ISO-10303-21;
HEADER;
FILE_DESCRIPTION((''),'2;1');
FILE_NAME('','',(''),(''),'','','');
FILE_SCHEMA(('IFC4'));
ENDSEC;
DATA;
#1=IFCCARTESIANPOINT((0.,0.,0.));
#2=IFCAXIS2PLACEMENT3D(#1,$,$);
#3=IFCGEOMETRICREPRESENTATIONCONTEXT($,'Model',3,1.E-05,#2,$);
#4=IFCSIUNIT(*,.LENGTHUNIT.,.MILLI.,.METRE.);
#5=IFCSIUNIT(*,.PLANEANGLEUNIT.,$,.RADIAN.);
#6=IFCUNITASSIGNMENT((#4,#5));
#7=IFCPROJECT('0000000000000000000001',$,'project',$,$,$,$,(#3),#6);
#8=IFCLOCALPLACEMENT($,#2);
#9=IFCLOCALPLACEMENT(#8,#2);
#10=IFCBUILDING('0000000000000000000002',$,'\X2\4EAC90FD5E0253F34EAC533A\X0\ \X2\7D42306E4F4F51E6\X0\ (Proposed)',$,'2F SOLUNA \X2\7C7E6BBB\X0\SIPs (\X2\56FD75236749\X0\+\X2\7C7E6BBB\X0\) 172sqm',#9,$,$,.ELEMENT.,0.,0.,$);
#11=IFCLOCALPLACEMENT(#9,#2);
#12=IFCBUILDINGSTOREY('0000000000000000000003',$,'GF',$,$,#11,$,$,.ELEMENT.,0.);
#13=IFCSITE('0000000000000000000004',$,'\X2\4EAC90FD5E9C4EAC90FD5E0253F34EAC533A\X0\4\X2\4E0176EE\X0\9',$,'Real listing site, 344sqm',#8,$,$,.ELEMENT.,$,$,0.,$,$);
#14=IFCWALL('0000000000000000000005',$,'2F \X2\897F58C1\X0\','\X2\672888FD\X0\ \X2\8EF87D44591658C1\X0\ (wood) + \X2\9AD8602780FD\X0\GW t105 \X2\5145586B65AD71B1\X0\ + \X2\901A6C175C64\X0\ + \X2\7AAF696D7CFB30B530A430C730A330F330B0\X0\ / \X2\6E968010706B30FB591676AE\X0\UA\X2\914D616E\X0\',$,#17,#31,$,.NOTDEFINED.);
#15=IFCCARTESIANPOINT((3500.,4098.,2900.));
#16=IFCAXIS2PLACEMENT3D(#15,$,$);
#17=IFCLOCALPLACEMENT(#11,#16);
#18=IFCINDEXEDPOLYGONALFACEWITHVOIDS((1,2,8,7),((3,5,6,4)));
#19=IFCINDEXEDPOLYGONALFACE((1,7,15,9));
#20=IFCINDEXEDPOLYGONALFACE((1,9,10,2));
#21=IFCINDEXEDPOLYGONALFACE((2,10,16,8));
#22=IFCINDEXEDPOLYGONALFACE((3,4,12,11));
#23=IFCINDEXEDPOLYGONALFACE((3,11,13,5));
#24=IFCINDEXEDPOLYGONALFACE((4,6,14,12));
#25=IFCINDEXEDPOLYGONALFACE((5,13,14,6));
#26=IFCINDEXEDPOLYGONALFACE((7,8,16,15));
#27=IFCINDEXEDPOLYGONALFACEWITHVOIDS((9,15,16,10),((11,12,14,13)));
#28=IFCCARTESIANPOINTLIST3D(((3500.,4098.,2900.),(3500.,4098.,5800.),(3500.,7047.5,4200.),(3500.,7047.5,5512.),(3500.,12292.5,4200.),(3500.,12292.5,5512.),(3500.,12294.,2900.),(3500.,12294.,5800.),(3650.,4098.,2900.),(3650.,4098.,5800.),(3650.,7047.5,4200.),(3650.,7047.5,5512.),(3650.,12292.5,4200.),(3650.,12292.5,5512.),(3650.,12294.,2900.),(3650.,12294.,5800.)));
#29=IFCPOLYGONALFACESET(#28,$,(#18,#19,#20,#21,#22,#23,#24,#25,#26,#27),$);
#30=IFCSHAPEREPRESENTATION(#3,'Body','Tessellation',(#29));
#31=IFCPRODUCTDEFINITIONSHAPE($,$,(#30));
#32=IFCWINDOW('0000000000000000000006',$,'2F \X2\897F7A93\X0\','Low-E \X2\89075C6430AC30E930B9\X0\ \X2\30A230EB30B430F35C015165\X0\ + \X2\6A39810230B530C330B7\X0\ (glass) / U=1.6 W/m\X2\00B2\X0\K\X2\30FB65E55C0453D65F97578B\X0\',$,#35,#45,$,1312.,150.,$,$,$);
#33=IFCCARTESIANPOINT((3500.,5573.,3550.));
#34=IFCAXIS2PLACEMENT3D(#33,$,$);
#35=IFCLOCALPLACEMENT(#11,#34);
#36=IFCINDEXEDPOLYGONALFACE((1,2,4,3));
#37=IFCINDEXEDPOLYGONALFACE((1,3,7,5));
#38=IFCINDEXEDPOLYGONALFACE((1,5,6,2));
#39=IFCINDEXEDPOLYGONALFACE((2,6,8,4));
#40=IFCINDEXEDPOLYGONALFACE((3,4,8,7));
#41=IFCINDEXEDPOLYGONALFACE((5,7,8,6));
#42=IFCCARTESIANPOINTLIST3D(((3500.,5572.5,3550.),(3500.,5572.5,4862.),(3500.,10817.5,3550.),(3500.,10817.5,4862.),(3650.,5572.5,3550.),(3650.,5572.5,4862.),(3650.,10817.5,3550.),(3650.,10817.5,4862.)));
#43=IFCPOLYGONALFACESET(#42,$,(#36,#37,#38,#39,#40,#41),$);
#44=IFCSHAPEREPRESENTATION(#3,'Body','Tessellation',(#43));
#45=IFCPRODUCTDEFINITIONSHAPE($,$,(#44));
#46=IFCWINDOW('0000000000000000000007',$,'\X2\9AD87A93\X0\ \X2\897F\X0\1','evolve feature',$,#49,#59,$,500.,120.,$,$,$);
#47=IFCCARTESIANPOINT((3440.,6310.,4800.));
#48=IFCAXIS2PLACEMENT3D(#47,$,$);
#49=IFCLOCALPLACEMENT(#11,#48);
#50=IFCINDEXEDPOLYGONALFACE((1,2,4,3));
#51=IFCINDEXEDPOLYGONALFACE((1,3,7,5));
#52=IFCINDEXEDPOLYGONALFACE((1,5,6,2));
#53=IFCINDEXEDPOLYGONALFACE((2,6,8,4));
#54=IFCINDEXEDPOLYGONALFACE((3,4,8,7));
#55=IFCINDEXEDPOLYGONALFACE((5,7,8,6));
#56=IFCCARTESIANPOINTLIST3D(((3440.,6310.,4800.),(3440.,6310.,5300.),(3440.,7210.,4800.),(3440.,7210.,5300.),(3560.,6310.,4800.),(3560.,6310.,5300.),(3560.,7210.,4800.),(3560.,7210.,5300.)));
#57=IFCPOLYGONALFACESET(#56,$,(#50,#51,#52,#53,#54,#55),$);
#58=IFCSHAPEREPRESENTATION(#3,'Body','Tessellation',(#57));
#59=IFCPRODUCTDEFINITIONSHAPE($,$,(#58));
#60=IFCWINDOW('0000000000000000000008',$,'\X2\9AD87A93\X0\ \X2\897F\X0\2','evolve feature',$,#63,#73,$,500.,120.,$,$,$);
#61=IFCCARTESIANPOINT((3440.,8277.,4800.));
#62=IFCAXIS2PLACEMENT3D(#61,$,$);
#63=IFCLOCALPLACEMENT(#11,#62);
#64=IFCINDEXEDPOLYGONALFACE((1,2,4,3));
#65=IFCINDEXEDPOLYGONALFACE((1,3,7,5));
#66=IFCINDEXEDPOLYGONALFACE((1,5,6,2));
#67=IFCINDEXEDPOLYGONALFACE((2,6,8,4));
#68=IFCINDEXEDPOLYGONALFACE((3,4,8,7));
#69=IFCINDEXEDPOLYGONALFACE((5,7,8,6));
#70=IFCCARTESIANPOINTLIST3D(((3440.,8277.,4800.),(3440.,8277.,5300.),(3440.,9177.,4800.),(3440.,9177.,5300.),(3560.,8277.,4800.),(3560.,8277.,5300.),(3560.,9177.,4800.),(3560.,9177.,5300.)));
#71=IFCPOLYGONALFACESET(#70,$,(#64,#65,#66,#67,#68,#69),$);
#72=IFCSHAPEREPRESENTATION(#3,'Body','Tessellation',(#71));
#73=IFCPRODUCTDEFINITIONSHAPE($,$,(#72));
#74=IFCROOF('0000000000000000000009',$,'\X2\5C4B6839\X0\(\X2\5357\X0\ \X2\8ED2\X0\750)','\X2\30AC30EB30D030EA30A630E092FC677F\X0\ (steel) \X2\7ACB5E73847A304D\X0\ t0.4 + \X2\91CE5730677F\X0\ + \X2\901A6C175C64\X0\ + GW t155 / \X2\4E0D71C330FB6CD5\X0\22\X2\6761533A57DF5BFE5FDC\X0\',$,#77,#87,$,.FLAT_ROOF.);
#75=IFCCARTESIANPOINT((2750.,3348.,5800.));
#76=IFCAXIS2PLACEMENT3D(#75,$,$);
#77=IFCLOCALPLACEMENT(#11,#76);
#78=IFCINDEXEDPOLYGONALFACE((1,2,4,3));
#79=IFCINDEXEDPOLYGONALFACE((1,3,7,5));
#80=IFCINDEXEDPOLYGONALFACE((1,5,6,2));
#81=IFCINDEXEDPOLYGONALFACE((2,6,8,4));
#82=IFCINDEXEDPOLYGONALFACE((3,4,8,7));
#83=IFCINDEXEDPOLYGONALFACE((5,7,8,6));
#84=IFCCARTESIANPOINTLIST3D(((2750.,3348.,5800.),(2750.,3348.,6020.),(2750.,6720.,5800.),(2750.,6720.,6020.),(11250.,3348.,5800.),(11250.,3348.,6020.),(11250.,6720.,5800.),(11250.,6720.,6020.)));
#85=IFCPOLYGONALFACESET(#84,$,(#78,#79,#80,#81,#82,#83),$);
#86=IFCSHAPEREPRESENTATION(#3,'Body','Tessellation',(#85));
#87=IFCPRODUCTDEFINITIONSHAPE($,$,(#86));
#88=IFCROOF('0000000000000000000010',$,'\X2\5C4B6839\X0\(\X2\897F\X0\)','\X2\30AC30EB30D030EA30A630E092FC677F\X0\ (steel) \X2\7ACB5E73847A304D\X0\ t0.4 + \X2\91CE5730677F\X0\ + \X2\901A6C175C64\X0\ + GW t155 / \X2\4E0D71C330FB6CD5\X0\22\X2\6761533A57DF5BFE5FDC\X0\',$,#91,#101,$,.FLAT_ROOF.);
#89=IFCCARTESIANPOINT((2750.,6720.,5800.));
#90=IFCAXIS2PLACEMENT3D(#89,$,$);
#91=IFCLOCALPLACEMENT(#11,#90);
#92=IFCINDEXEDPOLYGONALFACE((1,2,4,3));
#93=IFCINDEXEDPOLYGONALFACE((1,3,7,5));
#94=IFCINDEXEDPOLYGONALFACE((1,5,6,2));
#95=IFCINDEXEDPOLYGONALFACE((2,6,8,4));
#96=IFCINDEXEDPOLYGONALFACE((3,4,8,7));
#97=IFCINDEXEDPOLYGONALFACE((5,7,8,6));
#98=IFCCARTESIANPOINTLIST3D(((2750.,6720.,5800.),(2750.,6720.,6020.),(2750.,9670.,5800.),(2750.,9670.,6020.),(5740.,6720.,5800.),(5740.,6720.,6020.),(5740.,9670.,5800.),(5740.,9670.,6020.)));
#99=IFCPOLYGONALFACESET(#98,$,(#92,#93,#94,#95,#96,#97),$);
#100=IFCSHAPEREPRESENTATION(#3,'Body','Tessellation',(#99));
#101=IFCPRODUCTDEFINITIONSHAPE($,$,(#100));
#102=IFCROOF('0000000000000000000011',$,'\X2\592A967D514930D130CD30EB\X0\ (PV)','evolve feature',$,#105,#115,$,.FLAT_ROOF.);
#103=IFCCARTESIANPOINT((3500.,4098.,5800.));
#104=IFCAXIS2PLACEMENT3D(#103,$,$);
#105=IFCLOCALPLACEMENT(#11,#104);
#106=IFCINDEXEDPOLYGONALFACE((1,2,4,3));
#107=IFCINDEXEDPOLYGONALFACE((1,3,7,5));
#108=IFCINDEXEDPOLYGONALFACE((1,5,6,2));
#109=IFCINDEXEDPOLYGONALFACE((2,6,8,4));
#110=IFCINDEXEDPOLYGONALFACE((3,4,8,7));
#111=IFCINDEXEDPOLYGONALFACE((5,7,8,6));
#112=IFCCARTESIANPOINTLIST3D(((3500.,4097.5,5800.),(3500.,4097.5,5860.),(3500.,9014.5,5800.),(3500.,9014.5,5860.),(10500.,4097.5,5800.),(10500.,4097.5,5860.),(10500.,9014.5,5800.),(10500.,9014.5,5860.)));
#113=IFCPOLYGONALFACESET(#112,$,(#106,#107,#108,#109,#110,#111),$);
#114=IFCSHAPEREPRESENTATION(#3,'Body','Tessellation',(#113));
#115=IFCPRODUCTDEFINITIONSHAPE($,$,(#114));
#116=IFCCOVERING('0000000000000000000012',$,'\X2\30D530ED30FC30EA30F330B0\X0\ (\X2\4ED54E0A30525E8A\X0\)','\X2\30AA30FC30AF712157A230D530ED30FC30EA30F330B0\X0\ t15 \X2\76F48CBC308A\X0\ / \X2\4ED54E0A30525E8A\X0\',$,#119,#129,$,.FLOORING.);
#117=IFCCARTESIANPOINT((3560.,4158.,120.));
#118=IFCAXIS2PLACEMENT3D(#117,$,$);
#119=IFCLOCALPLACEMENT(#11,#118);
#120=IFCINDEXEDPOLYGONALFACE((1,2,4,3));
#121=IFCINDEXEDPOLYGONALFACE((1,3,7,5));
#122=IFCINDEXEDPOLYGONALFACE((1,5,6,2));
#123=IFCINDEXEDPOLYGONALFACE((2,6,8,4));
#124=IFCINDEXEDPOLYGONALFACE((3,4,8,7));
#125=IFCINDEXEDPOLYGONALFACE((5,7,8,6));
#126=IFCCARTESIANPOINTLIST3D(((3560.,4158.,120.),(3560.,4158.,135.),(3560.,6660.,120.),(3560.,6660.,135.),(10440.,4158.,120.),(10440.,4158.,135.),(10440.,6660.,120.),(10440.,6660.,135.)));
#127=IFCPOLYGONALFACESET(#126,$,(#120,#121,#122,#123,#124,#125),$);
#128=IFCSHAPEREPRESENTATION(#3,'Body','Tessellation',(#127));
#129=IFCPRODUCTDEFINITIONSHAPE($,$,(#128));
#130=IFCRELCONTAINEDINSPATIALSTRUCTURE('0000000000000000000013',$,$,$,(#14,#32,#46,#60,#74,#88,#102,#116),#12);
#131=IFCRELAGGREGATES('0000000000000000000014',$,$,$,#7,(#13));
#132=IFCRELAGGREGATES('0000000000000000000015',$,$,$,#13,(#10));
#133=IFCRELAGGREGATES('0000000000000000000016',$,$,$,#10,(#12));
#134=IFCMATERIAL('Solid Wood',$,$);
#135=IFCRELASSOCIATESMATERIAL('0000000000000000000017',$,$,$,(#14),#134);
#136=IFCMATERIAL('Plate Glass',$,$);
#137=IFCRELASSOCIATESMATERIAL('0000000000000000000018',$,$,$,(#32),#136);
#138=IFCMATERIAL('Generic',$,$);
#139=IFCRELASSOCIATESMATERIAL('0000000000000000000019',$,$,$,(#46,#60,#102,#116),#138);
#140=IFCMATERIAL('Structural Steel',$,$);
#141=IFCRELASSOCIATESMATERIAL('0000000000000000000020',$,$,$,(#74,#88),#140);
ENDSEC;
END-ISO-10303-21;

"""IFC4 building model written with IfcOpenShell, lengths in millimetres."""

from ifc_helpers import new_model, si_unit, frame, frame_2d, origin, place, context, project, spatial, rectangle, extrude, material, element, fill, save


model = new_model("IFC4")

# Units and contexts
model_context = context("Model", 3, precision=1e-05, world=origin())
ifc_project = project(units=[si_unit("LENGTHUNIT", "METRE", prefix="MILLI"), si_unit("PLANEANGLEUNIT", "RADIAN")], contexts=[model_context])

# Site, building, storey
site_placement = place(None, origin())
site = spatial("IfcSite", under=ifc_project, at=site_placement, Name="京都府京都市右京区4丁目9", ObjectType="Real listing site, 344sqm", CompositionType="ELEMENT", RefElevation=0.0)
building_placement = place(site_placement, origin())
building = spatial("IfcBuilding", under=site, at=building_placement, Name="京都市右京区 終の住処 (Proposed)", ObjectType="2F SOLUNA 籾殻SIPs (国産杉+籾殻) 172sqm", CompositionType="ELEMENT", ElevationOfRefHeight=0.0, ElevationOfTerrain=0.0)
storey_placement = place(building_placement, origin())
storey = spatial("IfcBuildingStorey", under=building, at=storey_placement, Name="GF", CompositionType="ELEMENT", Elevation=0.0)

# Shared definitions
ifc_material_1 = material(Name="Solid Wood")
ifc_material_2 = material(Name="Generic")

# Shared definitions
ifc_material_3 = material(Name="Plate Glass")

# Wall, openings, windows
wall_1_placement = place(storey_placement, frame((3500.0, 4098.0, 2900.0)))
wall_1 = element("IfcWall", 1, at=wall_1_placement, inside=storey, material=ifc_material_1, Name="2F 西壁", Description="木製 軸組外壁 (wood) + 高性能GW t105 充填断熱 + 通気層 + 窯業系サイディング / 準耐火・外皮UA配慮", PredefinedType="NOTDEFINED", context=model_context, shape_type="SweptSolid", body=[
    extrude(rectangle(XDim=150.0, YDim=8196.0, at=frame_2d((75.0, 4098.0))), frame((3500.0, 4098.0, 2900.0)), (0.0, 0.0, 1.0), 2900.0),
])
opening_1_placement = place(storey_placement, frame((3500.0, 5573.0, 3550.0)))
opening_1 = element("IfcOpeningElement", 2, at=opening_1_placement, cuts=wall_1, PredefinedType="NOTDEFINED", context=model_context, shape_type="SweptSolid", body=[
    extrude(rectangle(XDim=150.0, YDim=5245.0, at=frame_2d((75.0, 2622.0))), frame((3500.0, 5573.0, 3550.0)), (0.0, 0.0, 1.0), 1312.0),
])
opening_2_placement = place(storey_placement, frame((3440.0, 6310.0, 4800.0)))
opening_2 = element("IfcOpeningElement", 3, at=opening_2_placement, cuts=wall_1, PredefinedType="NOTDEFINED", context=model_context, shape_type="SweptSolid", body=[
    extrude(rectangle(XDim=120.0, YDim=900.0, at=frame_2d((60.0, 450.0))), frame((3440.0, 6310.0, 4800.0)), (0.0, 0.0, 1.0), 500.0),
])
opening_3_placement = place(storey_placement, frame((3440.0, 8277.0, 4800.0)))
opening_3 = element("IfcOpeningElement", 4, at=opening_3_placement, cuts=wall_1, PredefinedType="NOTDEFINED", context=model_context, shape_type="SweptSolid", body=[
    extrude(rectangle(XDim=120.0, YDim=900.0, at=frame_2d((60.0, 450.0))), frame((3440.0, 8277.0, 4800.0)), (0.0, 0.0, 1.0), 500.0),
])
window_1_placement = place(storey_placement, frame((3500.0, 5573.0, 3550.0)))
window_1 = element("IfcWindow", 5, at=window_1_placement, inside=storey, material=ifc_material_3, Name="2F 西窓", Description="Low-E 複層ガラス アルゴン封入 + 樹脂サッシ (glass) / U=1.6 W/m²K・日射取得型", OverallHeight=1312.0, OverallWidth=150.0, context=model_context, shape_type="SweptSolid", body=[
    extrude(rectangle(XDim=150.0, YDim=5245.0, at=frame_2d((75.0, 2622.0))), frame((3500.0, 5573.0, 3550.0)), (0.0, 0.0, 1.0), 1312.0),
])
fill(opening_1, window_1)
window_2_placement = place(storey_placement, frame((3440.0, 6310.0, 4800.0)))
window_2 = element("IfcWindow", 6, at=window_2_placement, inside=storey, material=ifc_material_2, Name="高窓 西1", Description="evolve feature", OverallHeight=500.0, OverallWidth=120.0, context=model_context, shape_type="SweptSolid", body=[
    extrude(rectangle(XDim=120.0, YDim=900.0, at=frame_2d((60.0, 450.0))), frame((3440.0, 6310.0, 4800.0)), (0.0, 0.0, 1.0), 500.0),
])
fill(opening_2, window_2)
window_3_placement = place(storey_placement, frame((3440.0, 8277.0, 4800.0)))
window_3 = element("IfcWindow", 7, at=window_3_placement, inside=storey, material=ifc_material_2, Name="高窓 西2", Description="evolve feature", OverallHeight=500.0, OverallWidth=120.0, context=model_context, shape_type="SweptSolid", body=[
    extrude(rectangle(XDim=120.0, YDim=900.0, at=frame_2d((60.0, 450.0))), frame((3440.0, 8277.0, 4800.0)), (0.0, 0.0, 1.0), 500.0),
])
fill(opening_3, window_3)

# Roofs
ifc_material_4 = material(Name="Structural Steel")
roof_1_placement = place(storey_placement, frame((2750.0, 3348.0, 5800.0)))
element("IfcRoof", 8, at=roof_1_placement, inside=storey, material=ifc_material_4, Name="屋根(南 軒750)", Description="ガルバリウム鋼板 (steel) 立平葺き t0.4 + 野地板 + 通気層 + GW t155 / 不燃・法22条区域対応", PredefinedType="FLAT_ROOF", context=model_context, shape_type="SweptSolid", body=[
    extrude(rectangle(XDim=8500.0, YDim=3372.0, at=frame_2d((4250.0, 1686.0))), frame((2750.0, 3348.0, 5800.0)), (0.0, 0.0, 1.0), 220.0),
])
roof_2_placement = place(storey_placement, frame((2750.0, 6720.0, 5800.0)))
element("IfcRoof", 9, at=roof_2_placement, inside=storey, material=ifc_material_4, Name="屋根(西)", Description="ガルバリウム鋼板 (steel) 立平葺き t0.4 + 野地板 + 通気層 + GW t155 / 不燃・法22条区域対応", PredefinedType="FLAT_ROOF", context=model_context, shape_type="SweptSolid", body=[
    extrude(rectangle(XDim=2990.0, YDim=2950.0, at=frame_2d((1495.0, 1475.0))), frame((2750.0, 6720.0, 5800.0)), (0.0, 0.0, 1.0), 220.0),
])
roof_3_placement = place(storey_placement, frame((3500.0, 4098.0, 5800.0)))
element("IfcRoof", 10, at=roof_3_placement, inside=storey, material=ifc_material_2, Name="太陽光パネル (PV)", Description="evolve feature", PredefinedType="FLAT_ROOF", context=model_context, shape_type="SweptSolid", body=[
    extrude(rectangle(XDim=7000.0, YDim=4917.0, at=frame_2d((3500.0, 2458.0))), frame((3500.0, 4098.0, 5800.0)), (0.0, 0.0, 1.0), 60.0),
])

# Covering
covering_placement = place(storey_placement, frame((3560.0, 4158.0, 120.0)))
element("IfcCovering", 11, at=covering_placement, inside=storey, material=ifc_material_2, Name="フローリング (仕上げ床)", Description="オーク無垢フローリング t15 直貼り / 仕上げ床", PredefinedType="FLOORING", context=model_context, shape_type="SweptSolid", body=[
    extrude(rectangle(XDim=6880.0, YDim=2502.0, at=frame_2d((3440.0, 1251.0))), frame((3560.0, 4158.0, 120.0)), (0.0, 0.0, 1.0), 15.0),
])

save(model, "model.ifc")
